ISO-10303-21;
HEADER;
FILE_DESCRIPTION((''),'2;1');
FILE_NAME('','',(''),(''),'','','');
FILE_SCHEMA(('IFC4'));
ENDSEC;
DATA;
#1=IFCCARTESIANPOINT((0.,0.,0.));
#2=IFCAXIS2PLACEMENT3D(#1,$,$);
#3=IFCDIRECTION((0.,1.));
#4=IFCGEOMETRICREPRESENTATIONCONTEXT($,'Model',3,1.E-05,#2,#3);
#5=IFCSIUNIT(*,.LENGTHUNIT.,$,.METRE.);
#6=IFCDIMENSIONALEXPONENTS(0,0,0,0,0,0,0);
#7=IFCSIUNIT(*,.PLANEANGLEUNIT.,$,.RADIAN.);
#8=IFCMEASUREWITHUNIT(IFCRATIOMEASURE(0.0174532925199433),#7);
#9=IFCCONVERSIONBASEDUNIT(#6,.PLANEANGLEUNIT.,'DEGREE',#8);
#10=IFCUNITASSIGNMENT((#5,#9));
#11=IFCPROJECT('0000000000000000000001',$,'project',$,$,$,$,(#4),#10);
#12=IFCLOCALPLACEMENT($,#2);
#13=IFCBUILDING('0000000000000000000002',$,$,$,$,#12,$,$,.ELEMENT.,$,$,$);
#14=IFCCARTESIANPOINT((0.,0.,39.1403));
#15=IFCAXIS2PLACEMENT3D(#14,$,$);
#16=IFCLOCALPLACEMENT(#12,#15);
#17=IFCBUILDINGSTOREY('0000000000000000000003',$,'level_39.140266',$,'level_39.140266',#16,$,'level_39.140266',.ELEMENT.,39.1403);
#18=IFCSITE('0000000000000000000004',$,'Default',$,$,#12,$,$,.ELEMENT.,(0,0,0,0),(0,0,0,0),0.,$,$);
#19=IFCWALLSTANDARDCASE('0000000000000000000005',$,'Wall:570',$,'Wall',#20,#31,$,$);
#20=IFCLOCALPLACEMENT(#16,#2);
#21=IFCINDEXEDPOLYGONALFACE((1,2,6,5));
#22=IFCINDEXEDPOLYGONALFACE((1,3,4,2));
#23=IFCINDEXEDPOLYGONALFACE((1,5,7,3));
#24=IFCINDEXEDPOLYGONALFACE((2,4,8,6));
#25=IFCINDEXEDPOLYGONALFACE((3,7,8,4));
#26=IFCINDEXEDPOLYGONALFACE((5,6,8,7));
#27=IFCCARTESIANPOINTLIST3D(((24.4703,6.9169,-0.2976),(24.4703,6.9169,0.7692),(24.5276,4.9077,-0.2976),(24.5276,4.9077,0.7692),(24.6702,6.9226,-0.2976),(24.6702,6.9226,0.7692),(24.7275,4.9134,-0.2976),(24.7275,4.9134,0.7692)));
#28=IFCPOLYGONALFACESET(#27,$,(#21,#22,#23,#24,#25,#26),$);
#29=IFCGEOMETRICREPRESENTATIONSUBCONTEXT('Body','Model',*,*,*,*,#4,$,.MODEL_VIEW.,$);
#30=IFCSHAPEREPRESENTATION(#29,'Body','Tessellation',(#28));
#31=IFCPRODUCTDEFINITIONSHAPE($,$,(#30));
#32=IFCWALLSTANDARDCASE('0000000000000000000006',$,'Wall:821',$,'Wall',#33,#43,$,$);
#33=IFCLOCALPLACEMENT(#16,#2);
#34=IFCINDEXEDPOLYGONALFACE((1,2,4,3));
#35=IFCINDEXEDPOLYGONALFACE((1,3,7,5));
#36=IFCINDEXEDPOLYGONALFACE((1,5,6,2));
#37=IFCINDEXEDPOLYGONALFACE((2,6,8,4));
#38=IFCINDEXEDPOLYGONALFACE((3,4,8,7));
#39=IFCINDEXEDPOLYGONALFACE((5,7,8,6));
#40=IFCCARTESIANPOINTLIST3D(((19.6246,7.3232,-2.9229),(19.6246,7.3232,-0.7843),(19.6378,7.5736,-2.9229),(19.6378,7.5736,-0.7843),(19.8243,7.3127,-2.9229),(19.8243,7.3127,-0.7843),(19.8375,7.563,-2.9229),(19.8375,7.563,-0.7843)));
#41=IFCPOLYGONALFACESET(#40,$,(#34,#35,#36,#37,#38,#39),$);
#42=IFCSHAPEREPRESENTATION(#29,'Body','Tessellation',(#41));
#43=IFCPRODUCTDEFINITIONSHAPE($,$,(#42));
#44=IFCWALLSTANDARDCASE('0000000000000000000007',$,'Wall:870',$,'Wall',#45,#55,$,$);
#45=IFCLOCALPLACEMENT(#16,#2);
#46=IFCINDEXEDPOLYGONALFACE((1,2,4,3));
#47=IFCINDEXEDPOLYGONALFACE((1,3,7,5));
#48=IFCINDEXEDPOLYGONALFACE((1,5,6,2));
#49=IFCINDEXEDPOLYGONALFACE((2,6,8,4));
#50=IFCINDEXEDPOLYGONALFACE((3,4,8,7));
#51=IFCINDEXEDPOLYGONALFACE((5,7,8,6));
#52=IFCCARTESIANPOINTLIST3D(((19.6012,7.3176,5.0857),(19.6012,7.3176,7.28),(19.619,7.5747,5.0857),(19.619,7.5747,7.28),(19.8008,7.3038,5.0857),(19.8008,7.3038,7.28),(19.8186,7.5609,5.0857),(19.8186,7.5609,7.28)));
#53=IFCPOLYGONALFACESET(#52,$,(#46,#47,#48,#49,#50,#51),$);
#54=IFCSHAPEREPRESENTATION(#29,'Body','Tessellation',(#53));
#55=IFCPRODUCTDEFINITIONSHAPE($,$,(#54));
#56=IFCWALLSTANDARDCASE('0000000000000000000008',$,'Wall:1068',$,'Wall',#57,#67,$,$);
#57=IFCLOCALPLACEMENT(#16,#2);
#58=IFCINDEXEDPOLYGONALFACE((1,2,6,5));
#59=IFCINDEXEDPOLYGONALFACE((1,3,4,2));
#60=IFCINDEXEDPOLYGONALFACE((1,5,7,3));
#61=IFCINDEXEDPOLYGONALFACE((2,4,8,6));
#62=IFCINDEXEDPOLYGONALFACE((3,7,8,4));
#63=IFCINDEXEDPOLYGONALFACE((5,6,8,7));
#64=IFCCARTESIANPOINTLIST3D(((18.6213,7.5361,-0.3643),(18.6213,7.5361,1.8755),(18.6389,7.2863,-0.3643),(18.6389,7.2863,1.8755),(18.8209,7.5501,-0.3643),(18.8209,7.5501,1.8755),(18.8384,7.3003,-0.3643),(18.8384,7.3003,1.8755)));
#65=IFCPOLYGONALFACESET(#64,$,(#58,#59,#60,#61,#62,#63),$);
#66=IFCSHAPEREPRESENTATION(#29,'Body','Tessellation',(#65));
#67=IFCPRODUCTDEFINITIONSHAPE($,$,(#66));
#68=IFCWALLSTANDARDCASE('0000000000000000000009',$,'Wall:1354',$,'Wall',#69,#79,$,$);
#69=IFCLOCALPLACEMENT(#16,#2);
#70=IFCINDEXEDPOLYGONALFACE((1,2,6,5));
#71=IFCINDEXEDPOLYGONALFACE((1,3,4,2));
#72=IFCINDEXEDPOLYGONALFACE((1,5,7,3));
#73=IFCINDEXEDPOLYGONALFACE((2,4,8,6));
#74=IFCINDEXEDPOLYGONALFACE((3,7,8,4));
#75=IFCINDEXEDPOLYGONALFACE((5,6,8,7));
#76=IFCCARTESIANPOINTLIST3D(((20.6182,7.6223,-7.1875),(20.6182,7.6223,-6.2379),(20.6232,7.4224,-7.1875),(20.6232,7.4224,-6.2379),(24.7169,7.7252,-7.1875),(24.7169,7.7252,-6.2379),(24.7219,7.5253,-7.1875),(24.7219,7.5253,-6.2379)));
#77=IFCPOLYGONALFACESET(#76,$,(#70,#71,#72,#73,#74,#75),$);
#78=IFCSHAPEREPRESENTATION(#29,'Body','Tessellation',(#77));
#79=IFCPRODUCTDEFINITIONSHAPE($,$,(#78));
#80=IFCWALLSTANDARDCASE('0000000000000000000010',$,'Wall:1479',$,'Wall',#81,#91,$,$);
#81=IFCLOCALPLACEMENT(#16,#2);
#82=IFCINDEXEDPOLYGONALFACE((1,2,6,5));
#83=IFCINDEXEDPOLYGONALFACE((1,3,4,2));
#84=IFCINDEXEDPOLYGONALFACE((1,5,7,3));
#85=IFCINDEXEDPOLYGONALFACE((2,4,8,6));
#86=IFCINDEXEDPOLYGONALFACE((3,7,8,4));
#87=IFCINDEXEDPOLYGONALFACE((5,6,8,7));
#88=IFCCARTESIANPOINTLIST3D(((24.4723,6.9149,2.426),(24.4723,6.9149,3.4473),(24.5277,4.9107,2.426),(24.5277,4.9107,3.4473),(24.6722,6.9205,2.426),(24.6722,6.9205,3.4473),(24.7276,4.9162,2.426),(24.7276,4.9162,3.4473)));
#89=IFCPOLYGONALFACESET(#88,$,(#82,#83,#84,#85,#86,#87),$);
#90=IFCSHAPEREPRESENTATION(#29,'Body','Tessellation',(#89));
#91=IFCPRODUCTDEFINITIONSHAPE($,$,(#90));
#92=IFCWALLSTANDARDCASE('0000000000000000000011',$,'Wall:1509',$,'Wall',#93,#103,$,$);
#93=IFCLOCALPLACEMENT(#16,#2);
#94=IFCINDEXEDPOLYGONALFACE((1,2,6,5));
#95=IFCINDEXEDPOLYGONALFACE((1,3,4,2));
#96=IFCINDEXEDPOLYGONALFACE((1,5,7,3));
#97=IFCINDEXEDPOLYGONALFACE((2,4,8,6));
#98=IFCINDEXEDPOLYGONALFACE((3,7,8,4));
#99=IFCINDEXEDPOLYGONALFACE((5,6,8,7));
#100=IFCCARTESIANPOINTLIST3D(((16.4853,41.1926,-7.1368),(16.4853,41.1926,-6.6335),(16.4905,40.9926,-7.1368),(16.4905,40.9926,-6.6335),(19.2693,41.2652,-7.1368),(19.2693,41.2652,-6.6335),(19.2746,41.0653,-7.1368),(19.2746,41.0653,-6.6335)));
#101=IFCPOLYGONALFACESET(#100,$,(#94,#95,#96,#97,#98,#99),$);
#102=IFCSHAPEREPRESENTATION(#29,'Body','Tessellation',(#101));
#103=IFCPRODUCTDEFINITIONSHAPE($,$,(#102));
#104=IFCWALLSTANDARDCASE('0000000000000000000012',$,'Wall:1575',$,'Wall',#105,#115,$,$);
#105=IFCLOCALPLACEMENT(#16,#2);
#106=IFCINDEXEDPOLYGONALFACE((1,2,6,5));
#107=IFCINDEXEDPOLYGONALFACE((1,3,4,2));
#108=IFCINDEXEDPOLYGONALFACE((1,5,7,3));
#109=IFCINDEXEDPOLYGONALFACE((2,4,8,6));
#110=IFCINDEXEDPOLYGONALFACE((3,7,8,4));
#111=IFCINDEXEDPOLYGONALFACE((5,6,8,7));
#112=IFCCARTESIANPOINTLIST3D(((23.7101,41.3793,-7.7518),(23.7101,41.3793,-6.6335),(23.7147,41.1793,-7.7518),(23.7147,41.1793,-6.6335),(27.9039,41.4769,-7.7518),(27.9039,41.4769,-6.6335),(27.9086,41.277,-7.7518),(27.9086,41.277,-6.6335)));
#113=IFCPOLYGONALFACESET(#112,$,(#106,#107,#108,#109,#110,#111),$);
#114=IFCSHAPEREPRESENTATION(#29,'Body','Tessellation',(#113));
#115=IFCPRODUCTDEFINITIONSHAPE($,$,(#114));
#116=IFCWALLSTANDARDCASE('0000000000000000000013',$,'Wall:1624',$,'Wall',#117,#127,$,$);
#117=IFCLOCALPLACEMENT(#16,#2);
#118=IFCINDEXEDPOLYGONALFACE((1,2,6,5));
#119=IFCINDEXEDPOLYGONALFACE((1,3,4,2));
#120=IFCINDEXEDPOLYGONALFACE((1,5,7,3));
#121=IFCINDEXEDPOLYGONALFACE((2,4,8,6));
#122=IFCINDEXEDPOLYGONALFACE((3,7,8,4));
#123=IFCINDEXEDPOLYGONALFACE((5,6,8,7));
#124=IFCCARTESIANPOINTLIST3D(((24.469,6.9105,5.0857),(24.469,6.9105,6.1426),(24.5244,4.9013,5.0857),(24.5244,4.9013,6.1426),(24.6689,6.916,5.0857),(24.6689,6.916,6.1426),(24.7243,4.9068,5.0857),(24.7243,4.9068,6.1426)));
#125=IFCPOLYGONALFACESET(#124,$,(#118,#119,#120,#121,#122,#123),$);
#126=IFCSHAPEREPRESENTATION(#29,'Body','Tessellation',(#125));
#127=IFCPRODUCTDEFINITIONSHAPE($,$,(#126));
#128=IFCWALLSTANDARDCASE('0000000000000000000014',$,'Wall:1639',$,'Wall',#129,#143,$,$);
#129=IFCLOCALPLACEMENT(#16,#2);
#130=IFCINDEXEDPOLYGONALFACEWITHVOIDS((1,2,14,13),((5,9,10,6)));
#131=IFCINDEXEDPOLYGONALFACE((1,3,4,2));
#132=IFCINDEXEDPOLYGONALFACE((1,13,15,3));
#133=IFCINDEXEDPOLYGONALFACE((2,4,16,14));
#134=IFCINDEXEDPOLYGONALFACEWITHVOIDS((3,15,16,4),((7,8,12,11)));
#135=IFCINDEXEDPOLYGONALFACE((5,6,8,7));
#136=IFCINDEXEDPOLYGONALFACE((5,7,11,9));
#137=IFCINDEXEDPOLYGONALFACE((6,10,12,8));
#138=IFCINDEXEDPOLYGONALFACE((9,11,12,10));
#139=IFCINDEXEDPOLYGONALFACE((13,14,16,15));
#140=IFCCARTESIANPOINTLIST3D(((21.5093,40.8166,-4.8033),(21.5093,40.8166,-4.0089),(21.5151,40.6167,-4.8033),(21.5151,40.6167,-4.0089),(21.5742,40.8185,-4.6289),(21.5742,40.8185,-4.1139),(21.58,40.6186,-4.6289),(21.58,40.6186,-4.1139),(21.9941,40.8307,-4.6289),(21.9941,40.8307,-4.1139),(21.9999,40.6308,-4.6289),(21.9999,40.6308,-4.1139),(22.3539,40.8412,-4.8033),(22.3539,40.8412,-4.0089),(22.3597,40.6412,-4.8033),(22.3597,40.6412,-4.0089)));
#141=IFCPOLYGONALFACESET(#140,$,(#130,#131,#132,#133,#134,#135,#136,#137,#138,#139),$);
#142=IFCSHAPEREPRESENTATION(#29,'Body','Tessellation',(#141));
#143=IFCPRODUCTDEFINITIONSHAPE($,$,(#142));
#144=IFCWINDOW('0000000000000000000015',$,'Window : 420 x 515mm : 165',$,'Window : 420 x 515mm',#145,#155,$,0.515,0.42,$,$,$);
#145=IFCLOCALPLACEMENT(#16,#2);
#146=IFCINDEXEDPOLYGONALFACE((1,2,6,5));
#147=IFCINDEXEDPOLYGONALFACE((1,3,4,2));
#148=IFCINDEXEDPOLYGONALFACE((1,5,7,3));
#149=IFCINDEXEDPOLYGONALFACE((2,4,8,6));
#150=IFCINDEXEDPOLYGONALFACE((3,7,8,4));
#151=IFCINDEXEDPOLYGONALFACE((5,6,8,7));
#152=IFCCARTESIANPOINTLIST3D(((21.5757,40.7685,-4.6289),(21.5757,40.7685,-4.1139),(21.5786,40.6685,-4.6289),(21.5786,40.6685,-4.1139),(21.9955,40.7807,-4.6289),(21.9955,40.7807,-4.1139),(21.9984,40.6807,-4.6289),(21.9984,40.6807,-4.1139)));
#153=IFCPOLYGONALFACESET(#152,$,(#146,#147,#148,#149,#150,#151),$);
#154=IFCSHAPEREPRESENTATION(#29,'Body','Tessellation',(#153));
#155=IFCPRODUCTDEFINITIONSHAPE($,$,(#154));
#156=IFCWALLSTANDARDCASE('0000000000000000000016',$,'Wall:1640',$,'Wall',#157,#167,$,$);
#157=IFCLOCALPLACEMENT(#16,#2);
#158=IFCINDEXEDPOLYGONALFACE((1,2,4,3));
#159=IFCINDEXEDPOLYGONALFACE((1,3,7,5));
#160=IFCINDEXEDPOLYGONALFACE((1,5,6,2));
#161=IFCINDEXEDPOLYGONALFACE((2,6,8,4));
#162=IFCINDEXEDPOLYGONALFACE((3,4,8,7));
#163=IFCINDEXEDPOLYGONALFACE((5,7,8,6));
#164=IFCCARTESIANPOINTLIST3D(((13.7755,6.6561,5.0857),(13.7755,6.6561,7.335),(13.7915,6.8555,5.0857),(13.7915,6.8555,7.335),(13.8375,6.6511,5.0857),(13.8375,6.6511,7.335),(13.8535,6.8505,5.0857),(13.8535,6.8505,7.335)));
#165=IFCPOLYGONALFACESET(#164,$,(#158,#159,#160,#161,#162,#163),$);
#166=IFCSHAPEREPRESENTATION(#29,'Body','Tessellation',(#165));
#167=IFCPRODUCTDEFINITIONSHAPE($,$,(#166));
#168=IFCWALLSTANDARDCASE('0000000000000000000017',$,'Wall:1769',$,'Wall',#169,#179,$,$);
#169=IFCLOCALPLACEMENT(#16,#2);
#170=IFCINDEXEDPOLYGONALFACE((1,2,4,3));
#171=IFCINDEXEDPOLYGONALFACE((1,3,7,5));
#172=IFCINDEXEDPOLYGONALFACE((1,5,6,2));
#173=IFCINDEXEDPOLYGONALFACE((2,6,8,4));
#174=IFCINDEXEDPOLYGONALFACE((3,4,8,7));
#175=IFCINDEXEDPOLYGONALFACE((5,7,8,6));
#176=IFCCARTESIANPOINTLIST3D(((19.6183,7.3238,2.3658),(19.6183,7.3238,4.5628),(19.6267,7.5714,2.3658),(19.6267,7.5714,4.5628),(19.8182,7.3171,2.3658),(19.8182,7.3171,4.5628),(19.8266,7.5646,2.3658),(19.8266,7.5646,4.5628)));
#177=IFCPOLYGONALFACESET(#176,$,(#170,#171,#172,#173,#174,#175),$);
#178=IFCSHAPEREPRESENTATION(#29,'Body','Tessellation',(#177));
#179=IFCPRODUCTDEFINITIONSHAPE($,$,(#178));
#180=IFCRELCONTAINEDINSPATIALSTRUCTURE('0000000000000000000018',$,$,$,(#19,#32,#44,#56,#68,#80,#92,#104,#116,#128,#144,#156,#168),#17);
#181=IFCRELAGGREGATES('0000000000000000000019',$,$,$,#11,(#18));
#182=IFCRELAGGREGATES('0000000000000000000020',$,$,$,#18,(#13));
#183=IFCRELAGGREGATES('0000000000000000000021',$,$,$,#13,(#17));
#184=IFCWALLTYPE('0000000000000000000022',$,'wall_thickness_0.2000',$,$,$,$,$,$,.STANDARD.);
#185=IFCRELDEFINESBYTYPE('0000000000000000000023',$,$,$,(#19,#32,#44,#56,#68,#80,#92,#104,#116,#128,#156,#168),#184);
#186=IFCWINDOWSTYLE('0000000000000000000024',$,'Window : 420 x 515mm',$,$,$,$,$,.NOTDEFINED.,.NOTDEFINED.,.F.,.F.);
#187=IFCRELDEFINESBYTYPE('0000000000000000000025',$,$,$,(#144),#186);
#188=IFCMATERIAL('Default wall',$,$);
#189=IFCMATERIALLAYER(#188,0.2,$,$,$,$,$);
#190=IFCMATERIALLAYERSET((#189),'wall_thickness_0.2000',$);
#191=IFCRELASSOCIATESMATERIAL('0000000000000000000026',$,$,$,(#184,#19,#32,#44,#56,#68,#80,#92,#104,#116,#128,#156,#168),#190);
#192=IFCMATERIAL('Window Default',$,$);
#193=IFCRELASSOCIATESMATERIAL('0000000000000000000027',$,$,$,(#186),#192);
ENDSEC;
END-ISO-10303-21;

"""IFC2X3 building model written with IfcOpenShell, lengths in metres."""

from ifc_helpers import new_model, entity, si_unit, converted_unit, direction, frame, frame_2d, origin, origin_2d_with_axis, place, context, subcontext, project, spatial, polyline, rectangle, outline, extrude, source, transform, mapped, material, layer, layer_set, layer_usage, type_object, type_shapes, element, fill, save


model = new_model("IFC2X3")

# Units and contexts
model_context = context("Model", 3, precision=1e-05, world=origin(), true_north=direction((0.0, 1.0)))
body_context = subcontext(model_context, "Body", "Model", "MODEL_VIEW")
ifc_project = project(units=[si_unit("LENGTHUNIT", "METRE"), converted_unit("PLANEANGLEUNIT", "DEGREE", entity("IfcRatioMeasure", 0.0174532925199433), si_unit("PLANEANGLEUNIT", "RADIAN"), dimensions=[0, 0, 0, 0, 0, 0, 0])], contexts=[model_context])

# Site, building, storey
placement_1 = place(None, origin())
site = spatial("IfcSite", under=ifc_project, at=placement_1, Name="Default", CompositionType="ELEMENT", RefLatitude=(0, 0, 0, 0), RefLongitude=(0, 0, 0, 0), RefElevation=0.0)
building = spatial("IfcBuilding", under=site, at=placement_1, CompositionType="ELEMENT")
storey_placement = place(placement_1, frame((0.0, 0.0, 39.1403)))
storey = spatial("IfcBuildingStorey", under=building, at=storey_placement, Name="level_39.140266", ObjectType="level_39.140266", LongName="level_39.140266", CompositionType="ELEMENT", Elevation=39.1403)

# Walls
ifc_material_1 = material(Name="Default wall")
ifc_layer = layer(ifc_material_1, 0.2)
ifc_layer_set = layer_set([ifc_layer], Name="wall_thickness_0.2000")
ifc_layer_usage = layer_usage(ifc_layer_set, "AXIS2", "POSITIVE", -0.1)
wall_type = type_object("IfcWallType", Name="wall_thickness_0.2000", PredefinedType="STANDARD", material=ifc_layer_set)
placement_2 = place(placement_1, frame((0.0, 0.0, 38.8427)))
wall_1_placement = place(placement_2, frame((24.6276, 4.9106, 0.0), z_axis=(0.0, 0.0, 1.0), x_axis=(-0.028513, 0.999593, 0.0)))
element("IfcWallStandardCase", 1, at=wall_1_placement, inside=storey, type_object=wall_type, material=ifc_layer_usage, Name="Wall:570", ObjectType="Wall", context=body_context, shape_type="SweptSolid", body=[
    extrude(outline(polyline([(2.01, -0.1), (2.01, 0.1), (0.0, 0.1), (0.0, -0.1), (2.01, -0.1)])), origin(), (0.0, 0.0, 1.0), 1.0669),
])
placement_3 = place(placement_1, frame((0.0, 0.0, 36.2174)))
wall_2_placement = place(placement_3, frame((19.7244, 7.3179, 0.0), z_axis=(0.0, 0.0, 1.0), x_axis=(0.052683, 0.998611, 0.0)))
element("IfcWallStandardCase", 2, at=wall_2_placement, inside=storey, type_object=wall_type, material=ifc_layer_usage, Name="Wall:821", ObjectType="Wall", context=body_context, shape_type="SweptSolid", body=[
    extrude(outline(polyline([(0.2507, -0.1), (0.2507, 0.1), (0.0, 0.1), (0.0, -0.1), (0.2507, -0.1)])), origin(), (0.0, 0.0, 1.0), 2.1386),
])
placement_4 = place(placement_1, frame((0.0, 0.0, 44.226)))
wall_3_placement = place(placement_4, frame((19.701, 7.3107, 0.0), z_axis=(0.0, 0.0, 1.0), x_axis=(0.069108, 0.997609, 0.0)))
element("IfcWallStandardCase", 3, at=wall_3_placement, inside=storey, type_object=wall_type, material=ifc_layer_usage, Name="Wall:870", ObjectType="Wall", context=body_context, shape_type="SweptSolid", body=[
    extrude(outline(polyline([(0.2578, -0.1), (0.2578, 0.1), (0.0, 0.1), (0.0, -0.1), (0.2578, -0.1)])), origin(), (0.0, 0.0, 1.0), 2.1942),
])
placement_5 = place(placement_1, frame((0.0, 0.0, 38.776)))
wall_4_placement = place(placement_5, frame((18.7211, 7.5431, 0.0), z_axis=(0.0, 0.0, 1.0), x_axis=(0.069962, -0.99755, 0.0)))
element("IfcWallStandardCase", 4, at=wall_4_placement, inside=storey, type_object=wall_type, material=ifc_layer_usage, Name="Wall:1068", ObjectType="Wall", context=body_context, shape_type="SweptSolid", body=[
    extrude(outline(polyline([(0.2504, -0.1), (0.2504, 0.1), (0.0, 0.1), (0.0, -0.1), (0.2504, -0.1)])), origin(), (0.0, 0.0, 1.0), 2.2397),
])
placement_6 = place(placement_1, frame((0.0, 0.0, 31.9528)))
wall_5_placement = place(placement_6, frame((20.6207, 7.5223, 0.0), z_axis=(0.0, 0.0, 1.0), x_axis=(0.999685, 0.025105, 0.0)))
element("IfcWallStandardCase", 5, at=wall_5_placement, inside=storey, type_object=wall_type, material=ifc_layer_usage, Name="Wall:1354", ObjectType="Wall", context=body_context, shape_type="SweptSolid", body=[
    extrude(outline(polyline([(4.1, -0.1), (4.1, 0.1), (0.0, 0.1), (0.0, -0.1), (4.1, -0.1)])), origin(), (0.0, 0.0, 1.0), 0.9497),
])
placement_7 = place(placement_1, frame((0.0, 0.0, 41.5663)))
wall_6_placement = place(placement_7, frame((24.6276, 4.9135, 0.0), z_axis=(0.0, 0.0, 1.0), x_axis=(-0.027649, 0.999618, 0.0)))
element("IfcWallStandardCase", 6, at=wall_6_placement, inside=storey, type_object=wall_type, material=ifc_layer_usage, Name="Wall:1479", ObjectType="Wall", context=body_context, shape_type="SweptSolid", body=[
    extrude(outline(polyline([(2.005, -0.1), (2.005, 0.1), (0.0, 0.1), (0.0, -0.1), (2.005, -0.1)])), origin(), (0.0, 0.0, 1.0), 1.0213),
])
placement_8 = place(placement_1, frame((0.0, 0.0, 32.0035)))
wall_7_placement = place(placement_8, frame((16.4879, 41.0926, 0.0), z_axis=(0.0, 0.0, 1.0), x_axis=(0.99966, 0.026093, 0.0)))
element("IfcWallStandardCase", 7, at=wall_7_placement, inside=storey, type_object=wall_type, material=ifc_layer_usage, Name="Wall:1509", ObjectType="Wall", context=body_context, shape_type="SweptSolid", body=[
    extrude(outline(polyline([(2.785, -0.1), (2.785, 0.1), (0.0, 0.1), (0.0, -0.1), (2.785, -0.1)])), origin(), (0.0, 0.0, 1.0), 0.5033),
])
placement_9 = place(placement_1, frame((0.0, 0.0, 31.3885)))
wall_8_placement = place(placement_9, frame((23.7124, 41.2793, 0.0), z_axis=(0.0, 0.0, 1.0), x_axis=(0.999729, 0.023284, 0.0)))
element("IfcWallStandardCase", 8, at=wall_8_placement, inside=storey, type_object=wall_type, material=ifc_layer_usage, Name="Wall:1575", ObjectType="Wall", context=body_context, shape_type="SweptSolid", body=[
    extrude(outline(polyline([(4.195, -0.1), (4.195, 0.1), (0.0, 0.1), (0.0, -0.1), (4.195, -0.1)])), origin(), (0.0, 0.0, 1.0), 1.1183),
])
placement_10 = place(placement_1, frame((0.0, 0.0, 44.226)))
wall_9_placement = place(placement_10, frame((24.6244, 4.904, 0.0), z_axis=(0.0, 0.0, 1.0), x_axis=(-0.027582, 0.99962, 0.0)))
element("IfcWallStandardCase", 9, at=wall_9_placement, inside=storey, type_object=wall_type, material=ifc_layer_usage, Name="Wall:1624", ObjectType="Wall", context=body_context, shape_type="SweptSolid", body=[
    extrude(outline(polyline([(2.01, -0.1), (2.01, 0.1), (0.0, 0.1), (0.0, -0.1), (2.01, -0.1)])), origin(), (0.0, 0.0, 1.0), 1.0569),
])

# Wall, opening, window
placement_11 = place(placement_1, frame((0.0, 0.0, 34.337)))
wall_10_placement = place(placement_11, frame((21.5122, 40.7166, 0.0), z_axis=(0.0, 0.0, 1.0), x_axis=(0.999577, 0.029077, 0.0)))
wall_10 = element("IfcWallStandardCase", 10, at=wall_10_placement, inside=storey, type_object=wall_type, material=ifc_layer_usage, Name="Wall:1639", ObjectType="Wall", context=body_context, shape_type="SweptSolid", body=[
    extrude(outline(polyline([(0.845, -0.1), (0.845, 0.1), (0.0, 0.1), (0.0, -0.1), (0.845, -0.1)])), origin(), (0.0, 0.0, 1.0), 0.7944),
])
opening_1_placement = place(wall_10_placement, frame((0.065, -0.1, 0.1744)))
opening_1 = element("IfcOpeningElement", 11, at=opening_1_placement, cuts=wall_10, ObjectType="Opening", context=body_context, shape_type="SweptSolid", body=[
    extrude(rectangle(XDim=0.42, YDim=0.515, at=frame_2d((0.2575, 0.21), x_axis=(0.0, 1.0))), frame((0.0, 0.0, 0.0), z_axis=(0.0, 1.0, 0.0), x_axis=(0.0, 0.0, 1.0)), (0.0, 0.0, 1.0), 0.2),
])
ifc_material_2 = material(Name="Window Default")
window_style_1 = type_object("IfcWindowStyle", Name="Window : 420 x 515mm", ConstructionType="NOTDEFINED", OperationType="NOTDEFINED", ParameterTakesPrecedence=False, Sizeable=False, material=ifc_material_2)
shared_shape_1 = source(origin(), body_context, "Body", "SweptSolid", [
    extrude(rectangle(XDim=0.1, YDim=0.42, at=origin_2d_with_axis()), frame((0.21, 0.1, 0.0), z_axis=(0.0, 0.0, 1.0), x_axis=(0.0, 1.0, 0.0)), (0.0, 0.0, 1.0), 0.515),
])
type_shapes(window_style_1, [shared_shape_1])
window_1_placement = place(opening_1_placement, origin())
window_1 = element("IfcWindow", 12, at=window_1_placement, inside=storey, type_object=window_style_1, Name="Window : 420 x 515mm : 165", ObjectType="Window : 420 x 515mm", OverallHeight=0.515, OverallWidth=0.42, context=body_context, shape_type="MappedRepresentation", body=[
    mapped(shared_shape_1, transform((0.0, 0.0, 0.0), scale=1.0)),
])
fill(opening_1, window_1)

# Walls
placement_12 = place(placement_1, frame((0.0, 0.0, 44.226)))
wall_11_placement = place(placement_12, frame((13.8455, 6.7508, 0.0), z_axis=(0.0, 0.0, 1.0), x_axis=(-0.9968, 0.079938, 0.0)))
element("IfcWallStandardCase", 13, at=wall_11_placement, inside=storey, type_object=wall_type, material=ifc_layer_usage, Name="Wall:1640", ObjectType="Wall", context=body_context, shape_type="SweptSolid", body=[
    extrude(outline(polyline([(0.0622, -0.1), (0.0622, 0.1), (0.0, 0.1), (0.0, -0.1), (0.0622, -0.1)])), origin(), (0.0, 0.0, 1.0), 2.2493),
])
placement_13 = place(placement_1, frame((0.0, 0.0, 41.5061)))
wall_12_placement = place(placement_13, frame((19.7183, 7.3204, 0.0), z_axis=(0.0, 0.0, 1.0), x_axis=(0.03377, 0.99943, 0.0)))
element("IfcWallStandardCase", 14, at=wall_12_placement, inside=storey, type_object=wall_type, material=ifc_layer_usage, Name="Wall:1769", ObjectType="Wall", context=body_context, shape_type="SweptSolid", body=[
    extrude(outline(polyline([(0.2477, -0.1), (0.2477, 0.1), (0.0, 0.1), (0.0, -0.1), (0.2477, -0.1)])), origin(), (0.0, 0.0, 1.0), 2.197),
])

save(model, "model.ifc")
